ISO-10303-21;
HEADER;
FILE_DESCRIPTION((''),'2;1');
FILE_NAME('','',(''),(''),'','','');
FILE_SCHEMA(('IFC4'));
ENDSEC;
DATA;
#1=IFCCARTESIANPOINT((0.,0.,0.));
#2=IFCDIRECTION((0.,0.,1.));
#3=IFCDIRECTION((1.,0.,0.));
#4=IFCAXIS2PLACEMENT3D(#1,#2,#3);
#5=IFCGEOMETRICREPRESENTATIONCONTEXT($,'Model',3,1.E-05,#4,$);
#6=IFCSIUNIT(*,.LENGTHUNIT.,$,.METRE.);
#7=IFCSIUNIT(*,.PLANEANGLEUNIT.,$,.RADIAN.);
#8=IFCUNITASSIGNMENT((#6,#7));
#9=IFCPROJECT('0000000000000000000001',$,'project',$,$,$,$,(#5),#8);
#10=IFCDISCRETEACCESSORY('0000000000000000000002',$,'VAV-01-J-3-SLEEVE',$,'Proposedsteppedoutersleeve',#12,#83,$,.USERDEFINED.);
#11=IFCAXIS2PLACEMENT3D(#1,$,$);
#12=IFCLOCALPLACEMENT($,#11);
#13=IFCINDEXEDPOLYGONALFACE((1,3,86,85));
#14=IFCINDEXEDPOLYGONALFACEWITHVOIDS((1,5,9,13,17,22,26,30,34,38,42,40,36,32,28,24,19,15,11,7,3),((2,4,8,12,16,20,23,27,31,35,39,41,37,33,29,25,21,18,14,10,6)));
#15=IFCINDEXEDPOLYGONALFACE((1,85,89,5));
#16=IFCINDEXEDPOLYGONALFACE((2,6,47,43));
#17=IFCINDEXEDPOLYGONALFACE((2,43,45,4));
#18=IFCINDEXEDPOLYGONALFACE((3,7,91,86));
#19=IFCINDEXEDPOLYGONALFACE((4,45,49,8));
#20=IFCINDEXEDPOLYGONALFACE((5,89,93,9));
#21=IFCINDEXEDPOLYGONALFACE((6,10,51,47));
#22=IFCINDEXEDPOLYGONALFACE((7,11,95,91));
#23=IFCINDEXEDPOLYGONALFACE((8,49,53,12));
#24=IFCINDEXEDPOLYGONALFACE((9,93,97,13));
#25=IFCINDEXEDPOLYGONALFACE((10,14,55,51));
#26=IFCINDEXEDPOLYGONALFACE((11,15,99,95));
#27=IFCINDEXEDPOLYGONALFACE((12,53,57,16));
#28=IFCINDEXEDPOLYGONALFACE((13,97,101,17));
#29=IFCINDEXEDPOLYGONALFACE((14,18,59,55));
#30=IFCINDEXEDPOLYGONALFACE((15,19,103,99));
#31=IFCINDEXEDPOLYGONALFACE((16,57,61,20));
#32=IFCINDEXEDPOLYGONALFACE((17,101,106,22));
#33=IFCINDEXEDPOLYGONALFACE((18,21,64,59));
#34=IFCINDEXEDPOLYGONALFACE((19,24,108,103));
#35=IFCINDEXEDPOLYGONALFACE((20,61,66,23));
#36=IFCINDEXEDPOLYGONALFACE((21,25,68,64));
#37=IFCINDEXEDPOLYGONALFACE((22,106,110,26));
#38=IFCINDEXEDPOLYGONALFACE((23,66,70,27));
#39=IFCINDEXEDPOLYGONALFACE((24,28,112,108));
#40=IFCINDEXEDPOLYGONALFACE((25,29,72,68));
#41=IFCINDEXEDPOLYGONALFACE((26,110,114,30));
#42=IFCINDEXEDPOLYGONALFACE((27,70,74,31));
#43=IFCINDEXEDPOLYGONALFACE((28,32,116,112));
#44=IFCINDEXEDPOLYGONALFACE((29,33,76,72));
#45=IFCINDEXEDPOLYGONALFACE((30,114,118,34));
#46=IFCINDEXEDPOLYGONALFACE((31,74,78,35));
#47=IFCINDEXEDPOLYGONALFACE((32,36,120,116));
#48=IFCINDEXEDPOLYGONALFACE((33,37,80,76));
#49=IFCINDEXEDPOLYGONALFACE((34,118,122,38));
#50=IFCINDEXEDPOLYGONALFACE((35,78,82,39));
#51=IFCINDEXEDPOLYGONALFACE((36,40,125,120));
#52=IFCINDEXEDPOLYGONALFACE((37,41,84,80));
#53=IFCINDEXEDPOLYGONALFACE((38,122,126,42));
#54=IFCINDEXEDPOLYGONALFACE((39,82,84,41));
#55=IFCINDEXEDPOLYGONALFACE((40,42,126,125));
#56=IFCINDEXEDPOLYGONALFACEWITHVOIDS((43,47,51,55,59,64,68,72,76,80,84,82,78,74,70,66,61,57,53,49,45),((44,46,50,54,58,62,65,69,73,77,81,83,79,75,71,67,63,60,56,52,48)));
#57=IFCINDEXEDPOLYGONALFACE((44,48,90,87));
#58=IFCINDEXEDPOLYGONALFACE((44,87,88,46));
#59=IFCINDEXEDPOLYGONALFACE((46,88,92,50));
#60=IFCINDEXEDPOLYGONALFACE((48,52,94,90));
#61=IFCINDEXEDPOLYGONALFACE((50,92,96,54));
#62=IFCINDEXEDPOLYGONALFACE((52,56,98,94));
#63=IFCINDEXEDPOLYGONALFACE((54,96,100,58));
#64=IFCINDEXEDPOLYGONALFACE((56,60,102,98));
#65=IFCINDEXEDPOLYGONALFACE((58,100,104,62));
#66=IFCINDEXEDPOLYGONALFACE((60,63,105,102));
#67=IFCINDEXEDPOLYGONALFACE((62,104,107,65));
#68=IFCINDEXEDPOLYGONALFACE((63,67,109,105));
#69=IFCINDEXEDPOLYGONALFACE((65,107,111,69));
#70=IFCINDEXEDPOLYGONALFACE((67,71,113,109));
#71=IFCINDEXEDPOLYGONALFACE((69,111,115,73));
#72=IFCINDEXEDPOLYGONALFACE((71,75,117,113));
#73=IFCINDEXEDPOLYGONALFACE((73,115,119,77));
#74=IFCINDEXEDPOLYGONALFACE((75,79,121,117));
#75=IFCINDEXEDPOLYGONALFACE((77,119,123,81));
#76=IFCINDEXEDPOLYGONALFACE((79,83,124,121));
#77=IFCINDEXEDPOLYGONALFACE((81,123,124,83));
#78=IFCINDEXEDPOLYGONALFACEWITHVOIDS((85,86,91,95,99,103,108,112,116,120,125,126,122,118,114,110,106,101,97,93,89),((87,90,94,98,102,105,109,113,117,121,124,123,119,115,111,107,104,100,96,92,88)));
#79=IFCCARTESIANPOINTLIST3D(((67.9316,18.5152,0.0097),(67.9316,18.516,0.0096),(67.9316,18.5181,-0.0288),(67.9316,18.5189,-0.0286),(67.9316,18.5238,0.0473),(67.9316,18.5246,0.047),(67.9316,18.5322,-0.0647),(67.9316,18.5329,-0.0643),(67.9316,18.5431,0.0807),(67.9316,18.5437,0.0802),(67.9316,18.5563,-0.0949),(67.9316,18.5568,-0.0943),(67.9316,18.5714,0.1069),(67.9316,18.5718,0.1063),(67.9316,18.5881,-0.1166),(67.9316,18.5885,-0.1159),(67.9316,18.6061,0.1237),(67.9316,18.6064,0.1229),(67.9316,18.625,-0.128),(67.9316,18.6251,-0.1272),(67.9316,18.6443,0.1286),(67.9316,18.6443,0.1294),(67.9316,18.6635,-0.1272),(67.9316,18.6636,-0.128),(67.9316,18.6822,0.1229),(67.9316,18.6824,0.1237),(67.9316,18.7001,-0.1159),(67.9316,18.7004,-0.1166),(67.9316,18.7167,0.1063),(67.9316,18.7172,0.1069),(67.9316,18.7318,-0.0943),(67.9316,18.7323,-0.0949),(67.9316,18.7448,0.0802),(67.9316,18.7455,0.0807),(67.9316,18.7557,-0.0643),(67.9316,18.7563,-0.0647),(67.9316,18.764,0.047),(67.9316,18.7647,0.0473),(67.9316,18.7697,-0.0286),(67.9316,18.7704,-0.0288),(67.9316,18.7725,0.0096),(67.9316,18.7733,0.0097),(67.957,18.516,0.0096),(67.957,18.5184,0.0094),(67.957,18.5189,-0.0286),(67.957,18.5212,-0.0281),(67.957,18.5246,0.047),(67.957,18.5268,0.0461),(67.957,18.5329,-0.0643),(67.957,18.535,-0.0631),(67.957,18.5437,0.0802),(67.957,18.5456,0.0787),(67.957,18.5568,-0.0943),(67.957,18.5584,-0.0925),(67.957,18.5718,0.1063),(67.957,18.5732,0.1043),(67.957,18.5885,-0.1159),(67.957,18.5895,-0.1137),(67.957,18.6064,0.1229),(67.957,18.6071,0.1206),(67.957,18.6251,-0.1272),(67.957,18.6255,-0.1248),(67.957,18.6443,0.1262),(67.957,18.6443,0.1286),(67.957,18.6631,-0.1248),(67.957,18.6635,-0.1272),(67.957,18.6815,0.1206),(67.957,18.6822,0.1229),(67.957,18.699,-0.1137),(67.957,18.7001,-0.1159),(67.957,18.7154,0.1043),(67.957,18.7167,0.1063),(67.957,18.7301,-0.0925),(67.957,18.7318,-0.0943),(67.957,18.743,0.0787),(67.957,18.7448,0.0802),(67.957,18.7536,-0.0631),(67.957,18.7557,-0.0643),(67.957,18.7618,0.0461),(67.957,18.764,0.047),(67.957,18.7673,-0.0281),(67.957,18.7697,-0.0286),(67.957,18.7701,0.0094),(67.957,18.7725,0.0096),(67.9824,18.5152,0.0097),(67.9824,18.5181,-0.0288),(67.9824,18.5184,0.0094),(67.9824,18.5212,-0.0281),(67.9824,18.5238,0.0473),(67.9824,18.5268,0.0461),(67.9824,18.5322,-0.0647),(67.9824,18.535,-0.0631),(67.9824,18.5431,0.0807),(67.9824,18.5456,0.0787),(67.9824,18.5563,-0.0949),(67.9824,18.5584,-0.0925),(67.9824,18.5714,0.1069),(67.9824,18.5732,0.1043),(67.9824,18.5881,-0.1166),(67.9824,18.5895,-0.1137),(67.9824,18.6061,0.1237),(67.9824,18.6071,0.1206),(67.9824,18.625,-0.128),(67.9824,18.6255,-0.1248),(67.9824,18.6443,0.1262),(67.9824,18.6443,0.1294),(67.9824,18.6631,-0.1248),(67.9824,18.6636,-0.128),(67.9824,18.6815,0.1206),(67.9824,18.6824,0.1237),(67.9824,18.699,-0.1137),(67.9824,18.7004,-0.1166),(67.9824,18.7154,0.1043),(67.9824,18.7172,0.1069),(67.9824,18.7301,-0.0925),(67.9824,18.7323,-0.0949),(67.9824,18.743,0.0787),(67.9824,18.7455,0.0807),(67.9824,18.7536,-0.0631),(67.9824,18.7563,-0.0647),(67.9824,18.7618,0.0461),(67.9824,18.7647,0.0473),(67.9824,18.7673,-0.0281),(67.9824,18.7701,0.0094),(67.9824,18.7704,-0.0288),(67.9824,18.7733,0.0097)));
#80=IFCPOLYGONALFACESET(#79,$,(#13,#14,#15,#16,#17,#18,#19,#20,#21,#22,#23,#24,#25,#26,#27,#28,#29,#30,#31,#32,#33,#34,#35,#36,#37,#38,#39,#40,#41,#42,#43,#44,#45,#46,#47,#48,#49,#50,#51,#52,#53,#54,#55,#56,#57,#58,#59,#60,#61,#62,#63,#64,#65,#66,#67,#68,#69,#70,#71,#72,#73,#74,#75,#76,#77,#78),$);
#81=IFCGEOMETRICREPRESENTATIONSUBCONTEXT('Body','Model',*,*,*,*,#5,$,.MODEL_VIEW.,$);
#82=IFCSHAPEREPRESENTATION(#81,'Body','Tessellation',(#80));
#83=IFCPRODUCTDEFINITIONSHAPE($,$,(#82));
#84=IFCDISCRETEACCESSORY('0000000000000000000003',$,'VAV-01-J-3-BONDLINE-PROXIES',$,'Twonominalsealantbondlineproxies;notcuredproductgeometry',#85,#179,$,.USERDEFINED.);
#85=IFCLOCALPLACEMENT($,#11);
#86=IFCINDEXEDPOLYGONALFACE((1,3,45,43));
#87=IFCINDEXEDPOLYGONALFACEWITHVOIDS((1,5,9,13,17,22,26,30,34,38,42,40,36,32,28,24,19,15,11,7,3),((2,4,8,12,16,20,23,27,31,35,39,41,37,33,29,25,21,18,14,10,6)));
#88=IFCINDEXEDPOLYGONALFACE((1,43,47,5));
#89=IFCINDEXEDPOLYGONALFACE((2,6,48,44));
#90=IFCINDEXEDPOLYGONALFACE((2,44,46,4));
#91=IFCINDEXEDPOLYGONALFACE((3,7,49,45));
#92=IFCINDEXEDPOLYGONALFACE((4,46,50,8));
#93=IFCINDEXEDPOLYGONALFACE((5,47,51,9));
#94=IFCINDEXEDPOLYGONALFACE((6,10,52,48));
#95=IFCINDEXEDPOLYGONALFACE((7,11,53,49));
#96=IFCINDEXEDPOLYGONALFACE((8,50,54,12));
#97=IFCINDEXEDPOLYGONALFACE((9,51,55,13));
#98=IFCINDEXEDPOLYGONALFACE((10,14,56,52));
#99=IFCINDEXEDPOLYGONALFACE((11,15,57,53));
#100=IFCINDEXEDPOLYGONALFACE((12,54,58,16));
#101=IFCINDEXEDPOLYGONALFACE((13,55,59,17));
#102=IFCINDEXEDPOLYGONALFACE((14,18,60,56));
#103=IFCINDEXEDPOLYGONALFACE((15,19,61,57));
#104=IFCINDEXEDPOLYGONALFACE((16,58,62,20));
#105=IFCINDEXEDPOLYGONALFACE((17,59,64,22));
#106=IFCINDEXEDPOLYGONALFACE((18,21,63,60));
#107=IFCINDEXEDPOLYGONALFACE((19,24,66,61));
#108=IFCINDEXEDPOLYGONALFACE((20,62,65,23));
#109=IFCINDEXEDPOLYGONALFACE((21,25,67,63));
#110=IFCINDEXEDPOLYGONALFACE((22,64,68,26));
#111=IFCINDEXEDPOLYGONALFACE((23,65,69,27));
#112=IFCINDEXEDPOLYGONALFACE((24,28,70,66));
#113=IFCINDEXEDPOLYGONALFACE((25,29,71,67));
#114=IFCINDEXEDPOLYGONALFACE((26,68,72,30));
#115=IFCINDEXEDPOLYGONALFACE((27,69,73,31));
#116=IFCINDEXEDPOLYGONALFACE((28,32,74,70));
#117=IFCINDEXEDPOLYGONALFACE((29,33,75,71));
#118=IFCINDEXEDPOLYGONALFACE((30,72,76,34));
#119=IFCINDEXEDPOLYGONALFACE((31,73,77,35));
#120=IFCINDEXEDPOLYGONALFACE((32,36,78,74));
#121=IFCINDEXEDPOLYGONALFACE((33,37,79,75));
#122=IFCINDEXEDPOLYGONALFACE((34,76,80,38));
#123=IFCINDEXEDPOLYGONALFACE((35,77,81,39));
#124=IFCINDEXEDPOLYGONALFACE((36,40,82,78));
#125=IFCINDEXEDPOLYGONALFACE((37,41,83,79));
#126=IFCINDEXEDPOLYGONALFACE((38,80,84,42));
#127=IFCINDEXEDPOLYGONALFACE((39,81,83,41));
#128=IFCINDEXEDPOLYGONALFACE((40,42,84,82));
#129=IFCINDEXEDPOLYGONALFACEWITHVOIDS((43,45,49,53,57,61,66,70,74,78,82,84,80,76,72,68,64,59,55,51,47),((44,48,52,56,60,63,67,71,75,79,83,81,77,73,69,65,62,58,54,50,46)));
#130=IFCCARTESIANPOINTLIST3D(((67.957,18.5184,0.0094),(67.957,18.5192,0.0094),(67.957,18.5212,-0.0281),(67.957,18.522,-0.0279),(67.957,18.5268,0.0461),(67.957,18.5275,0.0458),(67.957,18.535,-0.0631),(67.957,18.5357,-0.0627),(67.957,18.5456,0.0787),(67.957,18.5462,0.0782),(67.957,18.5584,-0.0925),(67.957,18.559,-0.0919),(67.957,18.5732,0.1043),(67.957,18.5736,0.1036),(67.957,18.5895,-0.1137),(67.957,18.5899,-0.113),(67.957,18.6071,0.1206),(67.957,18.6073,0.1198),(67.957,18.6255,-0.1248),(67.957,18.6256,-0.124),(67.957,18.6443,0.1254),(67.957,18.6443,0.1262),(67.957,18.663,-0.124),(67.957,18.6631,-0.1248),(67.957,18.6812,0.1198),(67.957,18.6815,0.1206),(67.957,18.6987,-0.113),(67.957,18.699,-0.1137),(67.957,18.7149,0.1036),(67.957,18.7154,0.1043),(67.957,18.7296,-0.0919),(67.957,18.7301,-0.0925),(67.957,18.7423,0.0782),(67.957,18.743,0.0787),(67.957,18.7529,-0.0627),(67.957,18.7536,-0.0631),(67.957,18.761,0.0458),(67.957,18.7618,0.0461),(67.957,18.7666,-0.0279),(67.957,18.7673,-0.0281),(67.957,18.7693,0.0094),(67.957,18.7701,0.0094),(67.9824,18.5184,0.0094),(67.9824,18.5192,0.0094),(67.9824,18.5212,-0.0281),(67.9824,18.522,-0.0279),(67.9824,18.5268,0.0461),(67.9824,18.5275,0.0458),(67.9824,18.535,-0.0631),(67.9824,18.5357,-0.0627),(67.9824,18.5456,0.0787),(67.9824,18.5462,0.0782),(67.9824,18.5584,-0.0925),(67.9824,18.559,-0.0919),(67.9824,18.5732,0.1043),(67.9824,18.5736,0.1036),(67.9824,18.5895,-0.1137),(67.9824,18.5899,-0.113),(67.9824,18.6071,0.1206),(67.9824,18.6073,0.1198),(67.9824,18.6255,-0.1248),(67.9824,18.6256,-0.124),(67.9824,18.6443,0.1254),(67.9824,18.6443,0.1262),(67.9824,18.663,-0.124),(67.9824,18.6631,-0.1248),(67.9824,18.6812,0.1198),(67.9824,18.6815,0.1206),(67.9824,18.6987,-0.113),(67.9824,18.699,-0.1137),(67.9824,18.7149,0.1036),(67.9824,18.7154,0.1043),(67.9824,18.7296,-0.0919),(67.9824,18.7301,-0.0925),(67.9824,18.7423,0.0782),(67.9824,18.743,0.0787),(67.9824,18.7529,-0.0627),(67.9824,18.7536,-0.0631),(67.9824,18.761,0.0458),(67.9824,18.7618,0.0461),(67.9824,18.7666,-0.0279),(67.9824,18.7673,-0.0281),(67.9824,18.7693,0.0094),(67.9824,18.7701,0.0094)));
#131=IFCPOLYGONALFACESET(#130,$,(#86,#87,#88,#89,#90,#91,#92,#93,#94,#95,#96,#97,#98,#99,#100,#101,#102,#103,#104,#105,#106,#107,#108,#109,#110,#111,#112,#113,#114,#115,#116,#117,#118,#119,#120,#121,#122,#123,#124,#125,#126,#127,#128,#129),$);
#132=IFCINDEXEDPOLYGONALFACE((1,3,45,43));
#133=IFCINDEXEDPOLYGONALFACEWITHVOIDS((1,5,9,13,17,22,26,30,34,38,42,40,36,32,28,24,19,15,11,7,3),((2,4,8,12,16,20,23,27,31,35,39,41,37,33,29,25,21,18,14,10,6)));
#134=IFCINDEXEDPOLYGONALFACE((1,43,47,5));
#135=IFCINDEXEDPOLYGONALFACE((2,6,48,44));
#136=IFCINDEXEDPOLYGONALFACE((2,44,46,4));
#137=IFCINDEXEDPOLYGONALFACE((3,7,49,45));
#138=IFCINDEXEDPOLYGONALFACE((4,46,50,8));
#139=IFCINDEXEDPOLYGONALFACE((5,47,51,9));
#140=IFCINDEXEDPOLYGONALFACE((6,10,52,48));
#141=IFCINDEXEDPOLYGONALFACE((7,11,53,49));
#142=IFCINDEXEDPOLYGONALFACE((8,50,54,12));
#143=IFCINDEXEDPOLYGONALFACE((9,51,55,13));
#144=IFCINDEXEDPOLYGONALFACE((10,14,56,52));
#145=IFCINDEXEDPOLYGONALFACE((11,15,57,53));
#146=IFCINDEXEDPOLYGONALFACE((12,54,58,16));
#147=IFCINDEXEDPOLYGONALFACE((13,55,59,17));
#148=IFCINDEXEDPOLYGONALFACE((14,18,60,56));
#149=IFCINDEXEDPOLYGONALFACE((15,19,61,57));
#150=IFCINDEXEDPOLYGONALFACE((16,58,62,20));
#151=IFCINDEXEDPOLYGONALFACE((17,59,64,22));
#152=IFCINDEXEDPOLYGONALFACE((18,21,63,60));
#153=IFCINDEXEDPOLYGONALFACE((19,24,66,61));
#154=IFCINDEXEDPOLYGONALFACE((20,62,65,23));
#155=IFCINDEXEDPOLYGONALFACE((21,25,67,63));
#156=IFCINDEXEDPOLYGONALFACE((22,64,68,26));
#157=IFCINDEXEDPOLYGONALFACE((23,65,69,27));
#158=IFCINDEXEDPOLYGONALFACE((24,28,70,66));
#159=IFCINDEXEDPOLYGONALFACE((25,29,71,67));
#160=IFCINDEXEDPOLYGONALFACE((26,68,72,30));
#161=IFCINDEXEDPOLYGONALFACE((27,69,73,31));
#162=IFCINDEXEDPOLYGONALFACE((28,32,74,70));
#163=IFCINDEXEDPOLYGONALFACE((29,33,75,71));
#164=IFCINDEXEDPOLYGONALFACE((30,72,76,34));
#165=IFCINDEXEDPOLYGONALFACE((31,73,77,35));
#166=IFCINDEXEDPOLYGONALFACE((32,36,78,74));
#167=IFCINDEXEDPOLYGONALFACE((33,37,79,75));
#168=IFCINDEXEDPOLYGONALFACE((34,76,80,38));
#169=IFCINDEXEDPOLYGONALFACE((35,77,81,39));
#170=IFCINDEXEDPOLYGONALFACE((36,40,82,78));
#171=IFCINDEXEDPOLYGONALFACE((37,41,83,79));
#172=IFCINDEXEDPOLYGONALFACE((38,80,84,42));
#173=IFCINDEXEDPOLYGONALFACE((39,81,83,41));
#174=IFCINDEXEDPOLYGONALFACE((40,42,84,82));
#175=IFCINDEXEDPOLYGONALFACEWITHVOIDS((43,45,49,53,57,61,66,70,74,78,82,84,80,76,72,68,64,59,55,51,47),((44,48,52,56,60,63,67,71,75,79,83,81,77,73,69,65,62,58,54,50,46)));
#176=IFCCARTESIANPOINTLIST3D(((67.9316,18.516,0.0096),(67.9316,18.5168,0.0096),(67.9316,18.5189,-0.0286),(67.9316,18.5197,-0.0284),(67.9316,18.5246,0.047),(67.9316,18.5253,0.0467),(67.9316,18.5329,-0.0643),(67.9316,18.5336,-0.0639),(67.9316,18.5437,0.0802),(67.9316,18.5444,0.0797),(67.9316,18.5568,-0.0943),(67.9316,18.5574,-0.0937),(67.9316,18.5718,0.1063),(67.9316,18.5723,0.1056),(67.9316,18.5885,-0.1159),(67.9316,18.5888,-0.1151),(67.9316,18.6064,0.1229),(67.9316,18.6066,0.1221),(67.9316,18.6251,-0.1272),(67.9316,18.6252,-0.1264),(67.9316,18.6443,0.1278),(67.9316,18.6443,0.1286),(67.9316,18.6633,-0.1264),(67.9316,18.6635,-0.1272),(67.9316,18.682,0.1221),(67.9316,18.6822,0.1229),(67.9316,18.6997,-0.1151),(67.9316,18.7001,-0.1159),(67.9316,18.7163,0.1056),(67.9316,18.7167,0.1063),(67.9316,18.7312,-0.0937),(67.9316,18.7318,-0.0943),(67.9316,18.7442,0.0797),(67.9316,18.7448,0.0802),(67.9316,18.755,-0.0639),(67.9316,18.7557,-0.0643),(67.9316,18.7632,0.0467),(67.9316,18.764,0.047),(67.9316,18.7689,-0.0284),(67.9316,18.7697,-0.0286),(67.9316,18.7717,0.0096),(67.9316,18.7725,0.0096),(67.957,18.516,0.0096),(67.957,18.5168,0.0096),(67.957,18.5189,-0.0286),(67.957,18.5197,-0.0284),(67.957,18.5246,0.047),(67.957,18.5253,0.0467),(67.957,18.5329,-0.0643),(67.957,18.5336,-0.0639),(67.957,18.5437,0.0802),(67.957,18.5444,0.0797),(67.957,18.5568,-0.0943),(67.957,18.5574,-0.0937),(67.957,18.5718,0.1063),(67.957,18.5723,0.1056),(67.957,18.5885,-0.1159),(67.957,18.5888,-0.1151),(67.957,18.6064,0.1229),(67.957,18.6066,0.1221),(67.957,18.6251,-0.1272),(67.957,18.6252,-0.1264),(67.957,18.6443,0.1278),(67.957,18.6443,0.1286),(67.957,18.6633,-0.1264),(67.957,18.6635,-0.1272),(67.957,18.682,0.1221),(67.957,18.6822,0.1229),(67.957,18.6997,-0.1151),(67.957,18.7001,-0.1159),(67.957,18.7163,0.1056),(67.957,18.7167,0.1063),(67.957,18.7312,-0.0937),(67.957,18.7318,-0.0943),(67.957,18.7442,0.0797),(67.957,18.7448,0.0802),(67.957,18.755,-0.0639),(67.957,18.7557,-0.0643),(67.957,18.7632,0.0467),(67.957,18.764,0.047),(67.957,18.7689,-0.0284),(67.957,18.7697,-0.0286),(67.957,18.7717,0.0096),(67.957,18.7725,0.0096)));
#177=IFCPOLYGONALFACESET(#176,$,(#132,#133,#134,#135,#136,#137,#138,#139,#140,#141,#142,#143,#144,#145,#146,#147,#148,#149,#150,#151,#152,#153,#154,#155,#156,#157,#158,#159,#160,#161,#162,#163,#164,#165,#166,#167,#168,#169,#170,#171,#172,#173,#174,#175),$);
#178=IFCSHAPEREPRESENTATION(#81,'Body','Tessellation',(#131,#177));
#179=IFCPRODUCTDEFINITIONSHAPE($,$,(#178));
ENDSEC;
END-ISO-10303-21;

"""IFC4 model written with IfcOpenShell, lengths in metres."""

from ifc_helpers import new_model, entity, si_unit, frame, origin_with_axes, place, context, subcontext, project, element, save


model = new_model("IFC4")

# Units and contexts
model_context = context("Model", 3, precision=1e-05, world=origin_with_axes())
body_context = subcontext(model_context, "Body", "Model", "MODEL_VIEW")
ifc_project = project(units=[si_unit("LENGTHUNIT", "METRE"), si_unit("PLANEANGLEUNIT", "RADIAN")], contexts=[model_context])

# Discrete accessories
discrete_accessory_1_placement = place(None, frame((67.957, 18.6443, 0.0), z_axis=(0.0, -1.0, 0.0), x_axis=(0.0, 0.0, 1.0)))
element("IfcDiscreteAccessory", 1, at=discrete_accessory_1_placement, Name="VAV-01-J-3-SLEEVE", ObjectType="Proposedsteppedoutersleeve", PredefinedType="USERDEFINED", context=body_context, shape_type="SweptSolid", body=[
    entity("IfcRevolvedAreaSolid", entity("IfcArbitraryClosedProfileDef", "AREA", None, entity("IfcPolyline", [entity("IfcCartesianPoint", [0.1262, -0.0254]), entity("IfcCartesianPoint", [0.1294, -0.0254]), entity("IfcCartesianPoint", [0.1294, 0.0254]), entity("IfcCartesianPoint", [0.1286, 0.0254]), entity("IfcCartesianPoint", [0.1286, 0.0]), entity("IfcCartesianPoint", [0.1262, 0.0]), entity("IfcCartesianPoint", [0.1262, -0.0254])])), entity("IfcAxis2Placement3D", entity("IfcCartesianPoint", [0.0, 0.0, 0.0])), entity("IfcAxis1Placement", entity("IfcCartesianPoint", [0.0, 0.0, 0.0]), entity("IfcDirection", [0.0, 1.0, 0.0])), 6.283185),
])
discrete_accessory_2_placement = place(None, frame((67.957, 18.6443, 0.0), z_axis=(0.0, -1.0, 0.0), x_axis=(0.0, 0.0, 1.0)))
element("IfcDiscreteAccessory", 2, at=discrete_accessory_2_placement, Name="VAV-01-J-3-BONDLINE-PROXIES", ObjectType="Twonominalsealantbondlineproxies;notcuredproductgeometry", PredefinedType="USERDEFINED", context=body_context, shape_type="SweptSolid", body=[
    entity("IfcRevolvedAreaSolid", entity("IfcArbitraryClosedProfileDef", "AREA", None, entity("IfcPolyline", [entity("IfcCartesianPoint", [0.1254, -0.0254]), entity("IfcCartesianPoint", [0.1262, -0.0254]), entity("IfcCartesianPoint", [0.1262, 0.0]), entity("IfcCartesianPoint", [0.1254, 0.0]), entity("IfcCartesianPoint", [0.1254, -0.0254])])), entity("IfcAxis2Placement3D", entity("IfcCartesianPoint", [0.0, 0.0, 0.0])), entity("IfcAxis1Placement", entity("IfcCartesianPoint", [0.0, 0.0, 0.0]), entity("IfcDirection", [0.0, 1.0, 0.0])), 6.283185),
    entity("IfcRevolvedAreaSolid", entity("IfcArbitraryClosedProfileDef", "AREA", None, entity("IfcPolyline", [entity("IfcCartesianPoint", [0.1278, 0.0]), entity("IfcCartesianPoint", [0.1286, 0.0]), entity("IfcCartesianPoint", [0.1286, 0.0254]), entity("IfcCartesianPoint", [0.1278, 0.0254]), entity("IfcCartesianPoint", [0.1278, 0.0])])), entity("IfcAxis2Placement3D", entity("IfcCartesianPoint", [0.0, 0.0, 0.0])), entity("IfcAxis1Placement", entity("IfcCartesianPoint", [0.0, 0.0, 0.0]), entity("IfcDirection", [0.0, 1.0, 0.0])), 6.283185),
])

save(model, "model.ifc")
